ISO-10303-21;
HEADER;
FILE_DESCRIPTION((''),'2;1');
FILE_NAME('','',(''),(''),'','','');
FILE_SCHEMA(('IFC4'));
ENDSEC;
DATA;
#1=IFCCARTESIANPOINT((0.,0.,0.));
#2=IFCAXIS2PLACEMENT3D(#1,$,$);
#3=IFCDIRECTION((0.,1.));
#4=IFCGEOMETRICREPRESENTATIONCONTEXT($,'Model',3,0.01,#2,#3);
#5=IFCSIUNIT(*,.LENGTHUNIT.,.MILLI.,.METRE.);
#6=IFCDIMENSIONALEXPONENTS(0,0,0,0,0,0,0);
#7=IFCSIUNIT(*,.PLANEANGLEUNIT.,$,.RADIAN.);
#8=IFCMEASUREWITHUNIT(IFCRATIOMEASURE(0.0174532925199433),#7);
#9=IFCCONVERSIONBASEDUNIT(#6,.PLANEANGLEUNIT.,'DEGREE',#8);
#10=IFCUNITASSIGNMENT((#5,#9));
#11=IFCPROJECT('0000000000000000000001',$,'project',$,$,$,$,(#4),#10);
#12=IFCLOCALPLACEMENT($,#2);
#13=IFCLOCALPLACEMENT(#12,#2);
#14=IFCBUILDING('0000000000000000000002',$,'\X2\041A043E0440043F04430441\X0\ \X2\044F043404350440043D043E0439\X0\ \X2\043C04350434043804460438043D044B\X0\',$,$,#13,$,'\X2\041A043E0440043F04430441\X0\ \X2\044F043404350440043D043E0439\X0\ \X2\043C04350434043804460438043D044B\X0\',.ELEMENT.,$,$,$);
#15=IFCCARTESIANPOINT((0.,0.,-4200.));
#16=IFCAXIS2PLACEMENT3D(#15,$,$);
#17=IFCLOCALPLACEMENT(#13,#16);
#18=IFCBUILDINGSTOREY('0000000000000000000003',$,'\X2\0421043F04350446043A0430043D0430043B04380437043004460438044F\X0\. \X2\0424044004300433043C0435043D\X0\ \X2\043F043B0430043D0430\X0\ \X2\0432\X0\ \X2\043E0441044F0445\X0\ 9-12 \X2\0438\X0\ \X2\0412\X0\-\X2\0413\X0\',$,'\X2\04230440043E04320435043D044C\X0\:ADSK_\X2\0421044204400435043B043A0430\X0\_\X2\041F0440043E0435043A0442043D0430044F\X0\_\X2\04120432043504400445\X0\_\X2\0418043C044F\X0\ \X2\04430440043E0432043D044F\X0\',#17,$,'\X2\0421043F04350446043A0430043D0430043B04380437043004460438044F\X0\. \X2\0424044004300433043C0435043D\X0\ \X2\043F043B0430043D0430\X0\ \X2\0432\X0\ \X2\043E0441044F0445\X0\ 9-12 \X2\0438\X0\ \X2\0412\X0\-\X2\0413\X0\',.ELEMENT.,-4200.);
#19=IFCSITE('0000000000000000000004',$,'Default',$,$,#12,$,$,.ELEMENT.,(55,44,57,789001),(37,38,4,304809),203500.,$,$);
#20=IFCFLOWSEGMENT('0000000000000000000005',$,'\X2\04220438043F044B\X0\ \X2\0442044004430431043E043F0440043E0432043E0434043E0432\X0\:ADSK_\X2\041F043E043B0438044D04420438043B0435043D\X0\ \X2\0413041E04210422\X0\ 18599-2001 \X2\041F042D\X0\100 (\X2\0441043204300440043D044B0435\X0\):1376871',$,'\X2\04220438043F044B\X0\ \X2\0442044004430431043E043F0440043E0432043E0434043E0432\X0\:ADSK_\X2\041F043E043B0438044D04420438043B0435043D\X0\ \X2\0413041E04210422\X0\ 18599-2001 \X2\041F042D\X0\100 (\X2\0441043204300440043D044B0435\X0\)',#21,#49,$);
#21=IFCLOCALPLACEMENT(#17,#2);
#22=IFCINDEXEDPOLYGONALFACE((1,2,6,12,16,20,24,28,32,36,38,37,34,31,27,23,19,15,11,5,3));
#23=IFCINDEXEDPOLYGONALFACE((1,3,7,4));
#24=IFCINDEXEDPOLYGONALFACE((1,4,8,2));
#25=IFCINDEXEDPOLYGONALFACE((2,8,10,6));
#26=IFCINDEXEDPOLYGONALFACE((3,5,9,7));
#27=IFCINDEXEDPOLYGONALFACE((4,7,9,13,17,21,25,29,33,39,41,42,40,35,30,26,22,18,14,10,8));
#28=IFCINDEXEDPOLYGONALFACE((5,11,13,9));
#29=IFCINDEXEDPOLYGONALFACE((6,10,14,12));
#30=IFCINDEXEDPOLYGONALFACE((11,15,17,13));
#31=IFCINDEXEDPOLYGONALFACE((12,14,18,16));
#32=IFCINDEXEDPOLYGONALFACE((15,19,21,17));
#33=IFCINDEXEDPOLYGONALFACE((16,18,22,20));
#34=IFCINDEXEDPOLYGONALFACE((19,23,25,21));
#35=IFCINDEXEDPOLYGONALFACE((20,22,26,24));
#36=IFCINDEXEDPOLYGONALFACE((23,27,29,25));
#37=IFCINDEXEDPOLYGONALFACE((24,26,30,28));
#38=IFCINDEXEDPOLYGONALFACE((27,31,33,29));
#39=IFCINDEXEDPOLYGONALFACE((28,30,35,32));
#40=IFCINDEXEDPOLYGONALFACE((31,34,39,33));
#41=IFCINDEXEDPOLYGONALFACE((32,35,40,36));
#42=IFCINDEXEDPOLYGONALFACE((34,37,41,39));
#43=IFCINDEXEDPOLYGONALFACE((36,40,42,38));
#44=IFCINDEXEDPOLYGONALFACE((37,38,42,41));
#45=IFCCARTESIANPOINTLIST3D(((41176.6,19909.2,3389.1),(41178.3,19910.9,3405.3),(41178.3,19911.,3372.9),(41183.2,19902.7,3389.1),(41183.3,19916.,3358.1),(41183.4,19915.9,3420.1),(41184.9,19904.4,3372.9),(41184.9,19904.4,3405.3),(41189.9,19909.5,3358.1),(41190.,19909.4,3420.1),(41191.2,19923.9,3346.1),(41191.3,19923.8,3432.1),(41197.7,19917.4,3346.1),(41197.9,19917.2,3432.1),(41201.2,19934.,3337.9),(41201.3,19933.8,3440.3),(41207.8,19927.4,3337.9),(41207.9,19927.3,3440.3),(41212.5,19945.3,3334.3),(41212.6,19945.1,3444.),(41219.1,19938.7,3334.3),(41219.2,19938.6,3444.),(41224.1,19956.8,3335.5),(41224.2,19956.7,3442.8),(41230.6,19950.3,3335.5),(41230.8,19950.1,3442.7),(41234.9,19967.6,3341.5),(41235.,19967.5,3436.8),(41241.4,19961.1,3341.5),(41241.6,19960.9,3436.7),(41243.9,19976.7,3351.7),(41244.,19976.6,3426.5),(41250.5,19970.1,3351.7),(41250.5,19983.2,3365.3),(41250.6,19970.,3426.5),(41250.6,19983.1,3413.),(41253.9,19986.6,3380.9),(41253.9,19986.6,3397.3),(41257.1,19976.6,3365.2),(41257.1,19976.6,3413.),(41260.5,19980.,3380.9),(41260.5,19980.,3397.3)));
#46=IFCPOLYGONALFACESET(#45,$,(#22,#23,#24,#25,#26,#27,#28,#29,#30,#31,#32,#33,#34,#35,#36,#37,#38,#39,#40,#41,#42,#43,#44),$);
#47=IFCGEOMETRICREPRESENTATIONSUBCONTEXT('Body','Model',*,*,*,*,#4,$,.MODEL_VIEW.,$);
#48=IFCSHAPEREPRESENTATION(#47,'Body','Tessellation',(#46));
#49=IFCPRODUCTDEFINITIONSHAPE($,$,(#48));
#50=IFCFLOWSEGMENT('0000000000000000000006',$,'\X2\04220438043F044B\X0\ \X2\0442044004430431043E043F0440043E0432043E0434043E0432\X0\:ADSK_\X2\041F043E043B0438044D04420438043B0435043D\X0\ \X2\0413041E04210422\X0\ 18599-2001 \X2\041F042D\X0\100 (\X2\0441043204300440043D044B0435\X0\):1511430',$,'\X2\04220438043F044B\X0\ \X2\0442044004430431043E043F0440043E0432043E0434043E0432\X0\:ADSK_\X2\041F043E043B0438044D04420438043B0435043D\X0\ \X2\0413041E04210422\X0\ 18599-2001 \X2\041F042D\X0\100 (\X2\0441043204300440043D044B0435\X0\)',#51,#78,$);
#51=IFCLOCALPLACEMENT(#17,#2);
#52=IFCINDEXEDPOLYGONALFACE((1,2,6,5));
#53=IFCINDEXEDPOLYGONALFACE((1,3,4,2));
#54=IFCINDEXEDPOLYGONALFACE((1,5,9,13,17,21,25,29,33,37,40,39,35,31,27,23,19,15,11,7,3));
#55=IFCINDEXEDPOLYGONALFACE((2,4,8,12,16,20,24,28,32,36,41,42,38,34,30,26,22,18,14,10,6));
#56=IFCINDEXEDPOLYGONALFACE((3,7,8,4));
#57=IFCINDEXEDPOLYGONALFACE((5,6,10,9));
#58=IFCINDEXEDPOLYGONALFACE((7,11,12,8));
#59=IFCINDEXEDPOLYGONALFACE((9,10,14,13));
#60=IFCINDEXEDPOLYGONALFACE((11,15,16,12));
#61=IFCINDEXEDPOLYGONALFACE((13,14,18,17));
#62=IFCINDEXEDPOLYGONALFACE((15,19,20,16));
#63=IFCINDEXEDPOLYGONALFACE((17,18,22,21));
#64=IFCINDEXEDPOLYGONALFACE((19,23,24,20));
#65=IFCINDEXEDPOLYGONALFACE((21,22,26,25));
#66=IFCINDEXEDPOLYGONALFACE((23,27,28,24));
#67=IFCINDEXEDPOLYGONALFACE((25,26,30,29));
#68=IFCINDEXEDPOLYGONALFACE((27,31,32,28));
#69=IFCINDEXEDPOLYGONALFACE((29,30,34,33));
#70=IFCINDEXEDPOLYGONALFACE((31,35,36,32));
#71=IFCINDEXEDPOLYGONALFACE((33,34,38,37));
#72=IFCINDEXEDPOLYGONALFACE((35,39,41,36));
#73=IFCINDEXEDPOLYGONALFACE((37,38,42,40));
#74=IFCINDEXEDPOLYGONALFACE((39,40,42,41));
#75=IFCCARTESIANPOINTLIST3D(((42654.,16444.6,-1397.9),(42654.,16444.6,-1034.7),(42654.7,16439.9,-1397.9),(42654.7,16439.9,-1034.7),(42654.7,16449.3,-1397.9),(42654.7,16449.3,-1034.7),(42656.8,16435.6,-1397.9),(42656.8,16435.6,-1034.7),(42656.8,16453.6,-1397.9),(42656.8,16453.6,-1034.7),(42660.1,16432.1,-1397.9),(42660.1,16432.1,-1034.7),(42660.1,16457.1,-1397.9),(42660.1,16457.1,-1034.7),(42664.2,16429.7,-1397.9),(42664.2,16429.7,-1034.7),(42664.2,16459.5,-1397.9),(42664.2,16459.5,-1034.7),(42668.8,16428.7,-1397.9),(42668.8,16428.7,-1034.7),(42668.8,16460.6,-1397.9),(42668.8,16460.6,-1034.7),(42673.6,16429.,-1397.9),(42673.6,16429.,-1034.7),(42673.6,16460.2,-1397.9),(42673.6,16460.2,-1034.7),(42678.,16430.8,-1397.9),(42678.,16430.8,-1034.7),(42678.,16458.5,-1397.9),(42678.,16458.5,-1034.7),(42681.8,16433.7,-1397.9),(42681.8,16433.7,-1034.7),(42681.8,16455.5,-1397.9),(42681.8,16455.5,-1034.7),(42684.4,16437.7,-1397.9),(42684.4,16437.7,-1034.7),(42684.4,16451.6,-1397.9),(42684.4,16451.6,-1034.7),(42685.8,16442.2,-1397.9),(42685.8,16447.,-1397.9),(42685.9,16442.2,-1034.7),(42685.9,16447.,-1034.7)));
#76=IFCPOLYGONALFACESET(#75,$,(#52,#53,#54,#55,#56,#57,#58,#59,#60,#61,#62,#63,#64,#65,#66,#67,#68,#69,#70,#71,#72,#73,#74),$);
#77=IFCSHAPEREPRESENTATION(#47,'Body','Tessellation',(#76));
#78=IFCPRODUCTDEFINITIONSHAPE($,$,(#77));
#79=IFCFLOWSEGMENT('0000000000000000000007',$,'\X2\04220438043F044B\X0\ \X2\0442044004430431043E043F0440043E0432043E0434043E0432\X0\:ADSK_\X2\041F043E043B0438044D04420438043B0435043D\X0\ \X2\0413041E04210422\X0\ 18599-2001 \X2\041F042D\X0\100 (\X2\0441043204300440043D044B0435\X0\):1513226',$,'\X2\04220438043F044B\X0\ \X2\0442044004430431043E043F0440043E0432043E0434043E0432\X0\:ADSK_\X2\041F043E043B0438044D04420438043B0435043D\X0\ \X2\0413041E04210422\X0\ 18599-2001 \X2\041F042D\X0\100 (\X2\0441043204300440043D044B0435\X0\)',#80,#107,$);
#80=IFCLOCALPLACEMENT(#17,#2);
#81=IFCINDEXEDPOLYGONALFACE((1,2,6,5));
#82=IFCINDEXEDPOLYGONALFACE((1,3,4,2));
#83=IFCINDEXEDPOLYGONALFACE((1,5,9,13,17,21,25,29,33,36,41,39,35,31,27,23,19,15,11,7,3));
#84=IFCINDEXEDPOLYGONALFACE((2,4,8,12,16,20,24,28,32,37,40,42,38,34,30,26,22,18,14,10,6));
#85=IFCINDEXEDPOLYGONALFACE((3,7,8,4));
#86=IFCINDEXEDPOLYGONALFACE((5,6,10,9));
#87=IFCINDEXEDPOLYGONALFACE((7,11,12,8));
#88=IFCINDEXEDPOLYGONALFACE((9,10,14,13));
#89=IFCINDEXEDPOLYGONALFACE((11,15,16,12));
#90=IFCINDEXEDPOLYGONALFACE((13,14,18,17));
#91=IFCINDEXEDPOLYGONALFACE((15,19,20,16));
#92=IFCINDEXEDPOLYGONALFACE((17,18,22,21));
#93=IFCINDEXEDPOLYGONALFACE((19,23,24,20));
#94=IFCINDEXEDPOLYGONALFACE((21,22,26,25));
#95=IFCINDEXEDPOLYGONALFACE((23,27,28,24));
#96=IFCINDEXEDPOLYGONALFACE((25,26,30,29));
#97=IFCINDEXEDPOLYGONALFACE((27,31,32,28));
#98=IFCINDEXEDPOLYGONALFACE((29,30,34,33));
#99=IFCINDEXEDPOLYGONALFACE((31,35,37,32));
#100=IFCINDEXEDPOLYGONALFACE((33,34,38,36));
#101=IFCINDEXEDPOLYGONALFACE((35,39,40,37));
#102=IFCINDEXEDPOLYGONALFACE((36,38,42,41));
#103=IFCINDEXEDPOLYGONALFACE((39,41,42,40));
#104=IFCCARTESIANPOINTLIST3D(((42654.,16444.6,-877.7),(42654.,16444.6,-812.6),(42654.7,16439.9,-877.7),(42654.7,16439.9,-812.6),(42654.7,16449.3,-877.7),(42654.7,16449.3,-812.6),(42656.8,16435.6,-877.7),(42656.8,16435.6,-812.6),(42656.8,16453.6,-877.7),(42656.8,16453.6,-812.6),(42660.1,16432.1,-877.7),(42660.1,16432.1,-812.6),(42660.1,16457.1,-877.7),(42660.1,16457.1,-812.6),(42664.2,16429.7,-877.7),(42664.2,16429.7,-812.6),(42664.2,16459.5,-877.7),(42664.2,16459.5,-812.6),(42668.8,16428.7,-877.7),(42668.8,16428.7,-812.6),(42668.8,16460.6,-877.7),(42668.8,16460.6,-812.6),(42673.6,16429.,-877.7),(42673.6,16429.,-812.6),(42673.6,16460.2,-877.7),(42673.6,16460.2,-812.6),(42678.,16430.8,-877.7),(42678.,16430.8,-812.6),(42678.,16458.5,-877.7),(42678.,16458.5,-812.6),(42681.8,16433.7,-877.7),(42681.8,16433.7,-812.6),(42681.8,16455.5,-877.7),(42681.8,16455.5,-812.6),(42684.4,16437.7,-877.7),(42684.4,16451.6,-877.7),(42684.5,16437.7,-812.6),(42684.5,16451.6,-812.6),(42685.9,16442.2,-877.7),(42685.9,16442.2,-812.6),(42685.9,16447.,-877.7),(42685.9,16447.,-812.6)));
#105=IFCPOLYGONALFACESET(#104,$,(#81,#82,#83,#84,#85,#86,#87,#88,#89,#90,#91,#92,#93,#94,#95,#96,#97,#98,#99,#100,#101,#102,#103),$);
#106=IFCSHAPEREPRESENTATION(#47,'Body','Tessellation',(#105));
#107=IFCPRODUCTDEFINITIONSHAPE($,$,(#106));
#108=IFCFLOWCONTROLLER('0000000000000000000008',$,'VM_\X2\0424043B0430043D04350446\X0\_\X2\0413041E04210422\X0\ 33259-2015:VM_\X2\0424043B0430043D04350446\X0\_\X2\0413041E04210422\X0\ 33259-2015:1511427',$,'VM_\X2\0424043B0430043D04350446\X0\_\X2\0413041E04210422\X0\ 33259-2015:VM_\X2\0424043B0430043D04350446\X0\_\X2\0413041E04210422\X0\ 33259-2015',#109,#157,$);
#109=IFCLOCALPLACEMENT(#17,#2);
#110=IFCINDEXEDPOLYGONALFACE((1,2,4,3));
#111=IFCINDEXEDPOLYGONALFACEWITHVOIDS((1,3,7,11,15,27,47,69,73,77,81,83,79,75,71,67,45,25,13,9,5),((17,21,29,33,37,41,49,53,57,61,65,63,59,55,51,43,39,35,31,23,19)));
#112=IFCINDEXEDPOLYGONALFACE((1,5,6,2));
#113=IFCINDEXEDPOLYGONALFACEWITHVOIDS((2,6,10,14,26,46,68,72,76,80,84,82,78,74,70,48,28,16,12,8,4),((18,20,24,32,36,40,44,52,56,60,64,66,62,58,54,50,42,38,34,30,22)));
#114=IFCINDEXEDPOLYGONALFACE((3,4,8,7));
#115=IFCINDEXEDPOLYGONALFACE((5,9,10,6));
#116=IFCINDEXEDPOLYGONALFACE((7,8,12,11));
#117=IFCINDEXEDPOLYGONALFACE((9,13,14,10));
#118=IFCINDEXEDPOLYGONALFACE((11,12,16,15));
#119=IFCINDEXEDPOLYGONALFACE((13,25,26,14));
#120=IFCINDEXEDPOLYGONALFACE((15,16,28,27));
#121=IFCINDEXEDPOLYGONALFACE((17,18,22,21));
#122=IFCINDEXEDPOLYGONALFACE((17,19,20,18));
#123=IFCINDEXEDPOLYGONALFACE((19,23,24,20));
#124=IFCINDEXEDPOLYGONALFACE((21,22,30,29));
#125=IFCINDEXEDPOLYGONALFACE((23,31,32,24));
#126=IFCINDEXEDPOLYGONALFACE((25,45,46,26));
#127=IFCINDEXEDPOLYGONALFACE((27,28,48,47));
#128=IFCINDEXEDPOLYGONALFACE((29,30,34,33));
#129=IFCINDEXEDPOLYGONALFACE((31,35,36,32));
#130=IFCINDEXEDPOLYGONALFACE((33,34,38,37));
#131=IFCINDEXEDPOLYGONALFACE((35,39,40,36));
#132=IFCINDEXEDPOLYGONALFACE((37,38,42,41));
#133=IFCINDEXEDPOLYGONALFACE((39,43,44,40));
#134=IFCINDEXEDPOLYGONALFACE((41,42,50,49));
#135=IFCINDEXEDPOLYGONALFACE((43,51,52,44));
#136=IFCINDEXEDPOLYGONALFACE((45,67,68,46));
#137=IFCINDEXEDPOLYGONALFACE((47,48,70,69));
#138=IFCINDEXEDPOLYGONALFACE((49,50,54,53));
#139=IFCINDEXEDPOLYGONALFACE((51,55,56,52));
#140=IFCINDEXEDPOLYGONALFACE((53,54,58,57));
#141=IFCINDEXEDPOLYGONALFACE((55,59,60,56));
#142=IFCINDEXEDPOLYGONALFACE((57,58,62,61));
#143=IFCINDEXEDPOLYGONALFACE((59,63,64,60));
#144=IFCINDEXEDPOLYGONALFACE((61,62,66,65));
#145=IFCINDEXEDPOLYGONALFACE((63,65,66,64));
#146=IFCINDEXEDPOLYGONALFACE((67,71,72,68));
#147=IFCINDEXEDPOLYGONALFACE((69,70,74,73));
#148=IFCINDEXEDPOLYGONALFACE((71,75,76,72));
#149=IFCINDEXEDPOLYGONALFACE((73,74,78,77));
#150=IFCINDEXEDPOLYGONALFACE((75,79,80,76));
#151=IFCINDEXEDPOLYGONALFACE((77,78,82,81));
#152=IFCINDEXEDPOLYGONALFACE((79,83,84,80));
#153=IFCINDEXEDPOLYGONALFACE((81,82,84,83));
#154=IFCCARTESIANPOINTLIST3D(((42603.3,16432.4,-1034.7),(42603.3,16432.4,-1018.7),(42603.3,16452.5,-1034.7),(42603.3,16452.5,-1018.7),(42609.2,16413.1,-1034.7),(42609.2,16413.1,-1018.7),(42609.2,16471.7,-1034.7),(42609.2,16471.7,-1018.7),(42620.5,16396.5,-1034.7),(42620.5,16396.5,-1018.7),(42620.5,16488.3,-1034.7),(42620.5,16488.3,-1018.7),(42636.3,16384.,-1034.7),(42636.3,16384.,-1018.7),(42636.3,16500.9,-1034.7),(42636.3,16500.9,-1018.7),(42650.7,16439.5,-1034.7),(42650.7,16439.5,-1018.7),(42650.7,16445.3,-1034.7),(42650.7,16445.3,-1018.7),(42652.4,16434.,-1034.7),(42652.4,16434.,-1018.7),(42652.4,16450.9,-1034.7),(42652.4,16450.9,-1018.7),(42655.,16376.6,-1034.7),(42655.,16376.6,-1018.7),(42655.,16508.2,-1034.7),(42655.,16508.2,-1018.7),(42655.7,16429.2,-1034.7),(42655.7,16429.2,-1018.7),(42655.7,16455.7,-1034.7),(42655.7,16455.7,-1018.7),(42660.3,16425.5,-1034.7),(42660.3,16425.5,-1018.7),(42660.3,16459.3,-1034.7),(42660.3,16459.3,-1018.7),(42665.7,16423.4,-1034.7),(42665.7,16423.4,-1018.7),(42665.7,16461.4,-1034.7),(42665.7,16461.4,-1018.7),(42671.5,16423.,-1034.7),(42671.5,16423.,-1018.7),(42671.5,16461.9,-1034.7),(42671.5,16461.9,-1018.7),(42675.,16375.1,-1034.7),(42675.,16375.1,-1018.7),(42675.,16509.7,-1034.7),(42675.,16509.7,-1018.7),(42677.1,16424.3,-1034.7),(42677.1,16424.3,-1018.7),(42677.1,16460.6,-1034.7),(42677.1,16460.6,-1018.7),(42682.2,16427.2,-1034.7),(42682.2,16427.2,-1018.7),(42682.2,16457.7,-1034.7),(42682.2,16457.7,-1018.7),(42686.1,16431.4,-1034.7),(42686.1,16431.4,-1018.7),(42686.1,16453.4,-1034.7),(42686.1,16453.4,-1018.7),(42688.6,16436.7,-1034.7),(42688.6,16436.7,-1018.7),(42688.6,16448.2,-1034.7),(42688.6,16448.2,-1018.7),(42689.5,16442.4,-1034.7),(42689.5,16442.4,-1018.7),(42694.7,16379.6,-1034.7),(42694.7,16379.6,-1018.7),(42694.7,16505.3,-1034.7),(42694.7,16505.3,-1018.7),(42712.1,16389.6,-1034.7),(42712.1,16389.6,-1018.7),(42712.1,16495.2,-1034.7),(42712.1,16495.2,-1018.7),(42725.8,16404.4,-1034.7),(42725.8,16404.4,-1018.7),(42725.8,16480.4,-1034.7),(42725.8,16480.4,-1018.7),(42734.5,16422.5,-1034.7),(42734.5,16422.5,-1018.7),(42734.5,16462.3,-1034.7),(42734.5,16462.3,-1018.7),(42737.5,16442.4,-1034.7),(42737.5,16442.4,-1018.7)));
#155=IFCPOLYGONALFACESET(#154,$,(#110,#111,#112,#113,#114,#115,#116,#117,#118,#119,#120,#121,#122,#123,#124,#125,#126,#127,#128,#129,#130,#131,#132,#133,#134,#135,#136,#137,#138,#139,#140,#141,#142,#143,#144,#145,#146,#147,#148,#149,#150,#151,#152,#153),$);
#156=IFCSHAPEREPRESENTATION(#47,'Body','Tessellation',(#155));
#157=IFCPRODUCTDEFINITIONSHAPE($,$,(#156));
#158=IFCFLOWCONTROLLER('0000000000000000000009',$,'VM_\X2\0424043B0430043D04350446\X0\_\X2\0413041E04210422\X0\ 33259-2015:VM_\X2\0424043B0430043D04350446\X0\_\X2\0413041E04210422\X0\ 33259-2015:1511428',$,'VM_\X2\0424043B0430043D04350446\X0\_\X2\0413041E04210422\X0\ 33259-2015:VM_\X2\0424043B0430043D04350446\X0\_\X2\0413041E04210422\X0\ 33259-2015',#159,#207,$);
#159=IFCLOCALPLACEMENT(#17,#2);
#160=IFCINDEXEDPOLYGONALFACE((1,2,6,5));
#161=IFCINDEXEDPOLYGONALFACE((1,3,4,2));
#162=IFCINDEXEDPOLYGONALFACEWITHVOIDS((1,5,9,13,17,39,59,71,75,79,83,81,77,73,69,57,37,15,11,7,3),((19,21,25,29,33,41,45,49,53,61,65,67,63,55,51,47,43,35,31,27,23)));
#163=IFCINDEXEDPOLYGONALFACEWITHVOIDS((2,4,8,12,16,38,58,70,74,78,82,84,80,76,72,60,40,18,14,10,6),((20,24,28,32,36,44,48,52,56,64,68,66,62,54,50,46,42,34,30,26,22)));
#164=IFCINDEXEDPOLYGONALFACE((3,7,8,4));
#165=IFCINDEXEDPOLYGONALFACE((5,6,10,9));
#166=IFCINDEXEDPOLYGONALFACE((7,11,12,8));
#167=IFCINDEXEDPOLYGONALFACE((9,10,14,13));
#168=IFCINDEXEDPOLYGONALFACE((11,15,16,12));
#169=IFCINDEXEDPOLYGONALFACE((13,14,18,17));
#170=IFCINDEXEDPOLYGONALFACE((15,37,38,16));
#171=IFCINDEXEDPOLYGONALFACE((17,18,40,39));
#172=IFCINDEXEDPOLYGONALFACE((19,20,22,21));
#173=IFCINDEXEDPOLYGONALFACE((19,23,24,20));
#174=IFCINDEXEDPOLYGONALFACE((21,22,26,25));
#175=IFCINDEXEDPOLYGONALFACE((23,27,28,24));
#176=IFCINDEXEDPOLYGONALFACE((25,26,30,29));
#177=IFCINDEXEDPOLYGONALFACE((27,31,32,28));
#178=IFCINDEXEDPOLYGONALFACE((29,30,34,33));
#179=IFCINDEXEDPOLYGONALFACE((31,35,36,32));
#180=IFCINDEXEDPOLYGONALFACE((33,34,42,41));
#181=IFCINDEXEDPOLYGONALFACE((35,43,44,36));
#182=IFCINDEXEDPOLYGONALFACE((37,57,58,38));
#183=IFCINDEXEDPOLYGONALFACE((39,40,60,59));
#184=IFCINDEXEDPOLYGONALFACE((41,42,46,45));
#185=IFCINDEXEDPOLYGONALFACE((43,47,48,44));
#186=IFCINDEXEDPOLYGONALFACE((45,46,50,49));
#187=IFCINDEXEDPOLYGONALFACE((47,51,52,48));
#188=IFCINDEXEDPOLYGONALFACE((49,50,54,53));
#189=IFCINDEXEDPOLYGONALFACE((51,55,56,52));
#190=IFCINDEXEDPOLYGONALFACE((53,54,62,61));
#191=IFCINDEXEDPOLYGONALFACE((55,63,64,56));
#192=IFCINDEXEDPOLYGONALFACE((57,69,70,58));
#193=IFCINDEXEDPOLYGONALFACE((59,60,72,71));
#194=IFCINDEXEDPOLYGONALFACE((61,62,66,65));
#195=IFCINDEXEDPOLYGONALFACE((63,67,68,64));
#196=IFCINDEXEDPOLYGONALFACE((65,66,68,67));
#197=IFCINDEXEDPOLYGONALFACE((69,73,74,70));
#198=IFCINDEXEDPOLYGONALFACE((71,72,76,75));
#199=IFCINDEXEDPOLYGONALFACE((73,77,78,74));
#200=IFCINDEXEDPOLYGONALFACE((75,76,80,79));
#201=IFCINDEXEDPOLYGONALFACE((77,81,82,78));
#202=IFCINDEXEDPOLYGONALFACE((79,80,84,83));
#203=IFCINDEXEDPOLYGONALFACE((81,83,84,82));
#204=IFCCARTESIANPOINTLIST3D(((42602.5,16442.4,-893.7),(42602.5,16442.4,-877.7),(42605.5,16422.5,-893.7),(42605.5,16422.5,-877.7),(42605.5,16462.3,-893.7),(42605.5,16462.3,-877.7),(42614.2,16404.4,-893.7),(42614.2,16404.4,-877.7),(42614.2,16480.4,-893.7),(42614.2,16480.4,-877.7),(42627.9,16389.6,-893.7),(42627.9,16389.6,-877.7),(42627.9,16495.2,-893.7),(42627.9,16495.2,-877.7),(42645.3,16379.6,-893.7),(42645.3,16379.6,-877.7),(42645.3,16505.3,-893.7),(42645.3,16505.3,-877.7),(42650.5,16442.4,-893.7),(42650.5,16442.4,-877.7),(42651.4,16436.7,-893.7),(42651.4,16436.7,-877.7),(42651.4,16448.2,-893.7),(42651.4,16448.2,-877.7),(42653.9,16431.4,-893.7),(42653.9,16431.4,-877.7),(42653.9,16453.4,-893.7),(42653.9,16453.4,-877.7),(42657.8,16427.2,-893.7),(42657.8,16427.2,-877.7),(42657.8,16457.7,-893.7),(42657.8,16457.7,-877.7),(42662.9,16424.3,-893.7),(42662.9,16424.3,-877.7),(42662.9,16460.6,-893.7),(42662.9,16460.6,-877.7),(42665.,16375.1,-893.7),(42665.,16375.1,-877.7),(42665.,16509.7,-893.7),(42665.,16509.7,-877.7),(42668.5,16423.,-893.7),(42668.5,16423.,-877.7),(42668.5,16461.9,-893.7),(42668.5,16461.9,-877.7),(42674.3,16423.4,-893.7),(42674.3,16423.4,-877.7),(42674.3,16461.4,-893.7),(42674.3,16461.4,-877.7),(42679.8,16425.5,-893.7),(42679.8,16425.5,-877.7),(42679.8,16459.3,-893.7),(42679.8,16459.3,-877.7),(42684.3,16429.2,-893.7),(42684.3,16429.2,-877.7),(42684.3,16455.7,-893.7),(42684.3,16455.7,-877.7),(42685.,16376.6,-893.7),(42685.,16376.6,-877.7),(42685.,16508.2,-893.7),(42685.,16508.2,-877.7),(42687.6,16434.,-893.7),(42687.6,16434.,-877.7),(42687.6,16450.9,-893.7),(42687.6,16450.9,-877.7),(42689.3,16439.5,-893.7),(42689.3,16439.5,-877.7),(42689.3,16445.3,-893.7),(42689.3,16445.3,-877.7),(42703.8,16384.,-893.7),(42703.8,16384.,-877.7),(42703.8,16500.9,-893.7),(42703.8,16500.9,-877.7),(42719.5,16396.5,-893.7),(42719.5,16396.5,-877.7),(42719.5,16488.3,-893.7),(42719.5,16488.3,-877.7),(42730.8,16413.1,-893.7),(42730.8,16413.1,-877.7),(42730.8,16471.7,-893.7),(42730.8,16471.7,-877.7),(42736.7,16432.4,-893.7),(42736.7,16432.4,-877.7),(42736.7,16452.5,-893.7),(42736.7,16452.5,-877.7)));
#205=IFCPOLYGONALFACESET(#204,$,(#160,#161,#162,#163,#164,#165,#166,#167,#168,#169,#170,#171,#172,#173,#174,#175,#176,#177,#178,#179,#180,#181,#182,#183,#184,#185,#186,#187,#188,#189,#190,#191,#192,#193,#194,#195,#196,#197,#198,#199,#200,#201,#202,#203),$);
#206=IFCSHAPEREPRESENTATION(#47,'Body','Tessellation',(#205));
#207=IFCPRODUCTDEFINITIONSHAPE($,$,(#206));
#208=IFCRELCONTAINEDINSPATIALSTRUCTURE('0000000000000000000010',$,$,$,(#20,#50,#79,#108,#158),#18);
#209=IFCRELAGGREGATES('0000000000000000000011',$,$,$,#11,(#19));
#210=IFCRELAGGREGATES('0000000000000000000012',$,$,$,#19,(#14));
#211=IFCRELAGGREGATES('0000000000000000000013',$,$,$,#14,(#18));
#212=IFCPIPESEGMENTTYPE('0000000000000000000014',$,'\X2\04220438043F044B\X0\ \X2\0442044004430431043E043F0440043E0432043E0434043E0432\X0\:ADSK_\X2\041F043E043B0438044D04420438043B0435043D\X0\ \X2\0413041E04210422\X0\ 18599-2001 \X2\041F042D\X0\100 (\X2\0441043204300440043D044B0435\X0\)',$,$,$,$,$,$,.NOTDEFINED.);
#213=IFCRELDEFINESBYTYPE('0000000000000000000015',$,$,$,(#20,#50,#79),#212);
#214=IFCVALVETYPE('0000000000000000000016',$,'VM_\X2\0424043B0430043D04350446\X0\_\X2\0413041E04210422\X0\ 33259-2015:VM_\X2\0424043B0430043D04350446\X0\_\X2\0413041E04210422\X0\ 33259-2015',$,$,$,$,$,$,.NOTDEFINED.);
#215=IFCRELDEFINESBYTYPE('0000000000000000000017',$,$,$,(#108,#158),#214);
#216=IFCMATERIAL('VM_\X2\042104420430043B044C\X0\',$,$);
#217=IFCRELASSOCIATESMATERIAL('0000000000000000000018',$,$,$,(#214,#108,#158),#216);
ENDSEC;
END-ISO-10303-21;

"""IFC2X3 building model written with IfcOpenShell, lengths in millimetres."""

from ifc_helpers import new_model, entity, si_unit, converted_unit, direction, frame, frame_2d, origin, origin_2d_with_axis, place, context, subcontext, project, spatial, circle, hollow_circle, extrude, source, transform, mapped, material, type_object, type_shapes, element, save


model = new_model("IFC2X3")

# Units and contexts
model_context = context("Model", 3, precision=0.01, world=origin(), true_north=direction((0.0, 1.0)))
body_context = subcontext(model_context, "Body", "Model", "MODEL_VIEW")
ifc_project = project(units=[si_unit("LENGTHUNIT", "METRE", prefix="MILLI"), converted_unit("PLANEANGLEUNIT", "DEGREE", entity("IfcRatioMeasure", 0.0174532925199433), si_unit("PLANEANGLEUNIT", "RADIAN"), dimensions=[0, 0, 0, 0, 0, 0, 0])], contexts=[model_context])

# Site, building, storey
site_placement = place(None, frame((0.0, 0.0, 0.0)))
site = spatial("IfcSite", under=ifc_project, at=site_placement, Name="Default", CompositionType="ELEMENT", RefLatitude=(55, 44, 57, 789001), RefLongitude=(37, 38, 4, 304809), RefElevation=203500.0)
building_placement = place(site_placement, origin())
building = spatial("IfcBuilding", under=site, at=building_placement, Name="Корпус ядерной медицины", LongName="Корпус ядерной медицины", CompositionType="ELEMENT")
storey_placement = place(building_placement, frame((0.0, 0.0, -4200.0)))
storey = spatial("IfcBuildingStorey", under=building, at=storey_placement, Name="Спецканализация. Фрагмен плана в осях 9-12 и В-Г", ObjectType="Уровень:ADSK_Стрелка_Проектная_Вверх_Имя уровня", LongName="Спецканализация. Фрагмен плана в осях 9-12 и В-Г", CompositionType="ELEMENT", Elevation=-4200.0)

# Flow segments
pipe_segment_type = type_object("IfcPipeSegmentType", Name="Типы трубопроводов:ADSK_Полиэтилен ГОСТ 18599-2001 ПЭ100 (сварные)", PredefinedType="NOTDEFINED")
flow_segment_1_placement = place(storey_placement, frame((41175.0, 19901.1, 3332.5)))
element("IfcFlowSegment", 1, at=flow_segment_1_placement, inside=storey, type_object=pipe_segment_type, Name="Типы трубопроводов:ADSK_Полиэтилен ГОСТ 18599-2001 ПЭ100 (сварные):1376871", ObjectType="Типы трубопроводов:ADSK_Полиэтилен ГОСТ 18599-2001 ПЭ100 (сварные)", context=body_context, shape_type="SweptSolid", body=[
    extrude(circle(Radius=55.0, at=origin_2d_with_axis()), frame((47.1, 40.5, 56.6), z_axis=(-0.707105, 0.707105, 0.002), x_axis=(-0.707107, -0.707107, 0.0)), (0.0, 0.0, 1.0), 9.3),
])
flow_segment_2_placement = place(storey_placement, frame((42652.4, 16427.0, -1397.9)))
element("IfcFlowSegment", 2, at=flow_segment_2_placement, inside=storey, type_object=pipe_segment_type, Name="Типы трубопроводов:ADSK_Полиэтилен ГОСТ 18599-2001 ПЭ100 (сварные):1511430", ObjectType="Типы трубопроводов:ADSK_Полиэтилен ГОСТ 18599-2001 ПЭ100 (сварные)", context=body_context, shape_type="SweptSolid", body=[
    extrude(circle(Radius=16.0, at=origin_2d_with_axis()), frame((17.6, 17.6, 0.0), z_axis=(0.000013, 0.0, 1.0), x_axis=(-1.0, 0.0, 0.000013)), (0.0, 0.0, 1.0), 363.2),
])
flow_segment_3_placement = place(storey_placement, frame((42652.4, 16427.0, -877.7)))
element("IfcFlowSegment", 3, at=flow_segment_3_placement, inside=storey, type_object=pipe_segment_type, Name="Типы трубопроводов:ADSK_Полиэтилен ГОСТ 18599-2001 ПЭ100 (сварные):1513226", ObjectType="Типы трубопроводов:ADSK_Полиэтилен ГОСТ 18599-2001 ПЭ100 (сварные)", context=body_context, shape_type="SweptSolid", body=[
    extrude(circle(Radius=16.0, at=origin_2d_with_axis()), frame((17.6, 17.6, 0.0), z_axis=(0.000017, 0.0, 1.0), x_axis=(-1.0, 0.0, 0.000017)), (0.0, 0.0, 1.0), 65.1),
])

# Flow controllers
ifc_material_1 = material(Name="VM_Сталь")
valve_type_1 = type_object("IfcValveType", Name="VM_Фланец_ГОСТ 33259-2015:VM_Фланец_ГОСТ 33259-2015", PredefinedType="NOTDEFINED", material=ifc_material_1)
shared_shape_1 = source(origin(), body_context, "Body", "SweptSolid", [
    extrude(hollow_circle(Radius=67.5, WallThickness=48.0, at=frame_2d((0.0, 0.0), x_axis=(1.0, 0.0))), frame((0.0, 0.0, 0.0), z_axis=(1.0, 0.0, 0.0), x_axis=(0.0, 1.0, 0.0)), (0.0, 0.0, 1.0), 16.0),
])
type_shapes(valve_type_1, [shared_shape_1])
for number, where, z_axis, x_axis, name in (
    (4, (42670.0, 16442.4, -1034.7), (0.0, 1.0, 0.0), (0.000013, 0.0, 1.0), "VM_Фланец_ГОСТ 33259-2015:VM_Фланец_ГОСТ 33259-2015:1511427"),
    (5, (42670.0, 16442.4, -877.7), (0.0, 1.0, 0.0), (-0.000013, 0.0, -1.0), "VM_Фланец_ГОСТ 33259-2015:VM_Фланец_ГОСТ 33259-2015:1511428"),
):
    element("IfcFlowController", number, at=place(storey_placement, frame(where, z_axis=z_axis, x_axis=x_axis)), inside=storey, type_object=valve_type_1, material=ifc_material_1, Name=name, ObjectType="VM_Фланец_ГОСТ 33259-2015:VM_Фланец_ГОСТ 33259-2015", context=body_context, shape_type="MappedRepresentation", body=[
        mapped(shared_shape_1, transform((0.0, 0.0, 0.0), scale=1.0)),
    ])

save(model, "model.ifc")
